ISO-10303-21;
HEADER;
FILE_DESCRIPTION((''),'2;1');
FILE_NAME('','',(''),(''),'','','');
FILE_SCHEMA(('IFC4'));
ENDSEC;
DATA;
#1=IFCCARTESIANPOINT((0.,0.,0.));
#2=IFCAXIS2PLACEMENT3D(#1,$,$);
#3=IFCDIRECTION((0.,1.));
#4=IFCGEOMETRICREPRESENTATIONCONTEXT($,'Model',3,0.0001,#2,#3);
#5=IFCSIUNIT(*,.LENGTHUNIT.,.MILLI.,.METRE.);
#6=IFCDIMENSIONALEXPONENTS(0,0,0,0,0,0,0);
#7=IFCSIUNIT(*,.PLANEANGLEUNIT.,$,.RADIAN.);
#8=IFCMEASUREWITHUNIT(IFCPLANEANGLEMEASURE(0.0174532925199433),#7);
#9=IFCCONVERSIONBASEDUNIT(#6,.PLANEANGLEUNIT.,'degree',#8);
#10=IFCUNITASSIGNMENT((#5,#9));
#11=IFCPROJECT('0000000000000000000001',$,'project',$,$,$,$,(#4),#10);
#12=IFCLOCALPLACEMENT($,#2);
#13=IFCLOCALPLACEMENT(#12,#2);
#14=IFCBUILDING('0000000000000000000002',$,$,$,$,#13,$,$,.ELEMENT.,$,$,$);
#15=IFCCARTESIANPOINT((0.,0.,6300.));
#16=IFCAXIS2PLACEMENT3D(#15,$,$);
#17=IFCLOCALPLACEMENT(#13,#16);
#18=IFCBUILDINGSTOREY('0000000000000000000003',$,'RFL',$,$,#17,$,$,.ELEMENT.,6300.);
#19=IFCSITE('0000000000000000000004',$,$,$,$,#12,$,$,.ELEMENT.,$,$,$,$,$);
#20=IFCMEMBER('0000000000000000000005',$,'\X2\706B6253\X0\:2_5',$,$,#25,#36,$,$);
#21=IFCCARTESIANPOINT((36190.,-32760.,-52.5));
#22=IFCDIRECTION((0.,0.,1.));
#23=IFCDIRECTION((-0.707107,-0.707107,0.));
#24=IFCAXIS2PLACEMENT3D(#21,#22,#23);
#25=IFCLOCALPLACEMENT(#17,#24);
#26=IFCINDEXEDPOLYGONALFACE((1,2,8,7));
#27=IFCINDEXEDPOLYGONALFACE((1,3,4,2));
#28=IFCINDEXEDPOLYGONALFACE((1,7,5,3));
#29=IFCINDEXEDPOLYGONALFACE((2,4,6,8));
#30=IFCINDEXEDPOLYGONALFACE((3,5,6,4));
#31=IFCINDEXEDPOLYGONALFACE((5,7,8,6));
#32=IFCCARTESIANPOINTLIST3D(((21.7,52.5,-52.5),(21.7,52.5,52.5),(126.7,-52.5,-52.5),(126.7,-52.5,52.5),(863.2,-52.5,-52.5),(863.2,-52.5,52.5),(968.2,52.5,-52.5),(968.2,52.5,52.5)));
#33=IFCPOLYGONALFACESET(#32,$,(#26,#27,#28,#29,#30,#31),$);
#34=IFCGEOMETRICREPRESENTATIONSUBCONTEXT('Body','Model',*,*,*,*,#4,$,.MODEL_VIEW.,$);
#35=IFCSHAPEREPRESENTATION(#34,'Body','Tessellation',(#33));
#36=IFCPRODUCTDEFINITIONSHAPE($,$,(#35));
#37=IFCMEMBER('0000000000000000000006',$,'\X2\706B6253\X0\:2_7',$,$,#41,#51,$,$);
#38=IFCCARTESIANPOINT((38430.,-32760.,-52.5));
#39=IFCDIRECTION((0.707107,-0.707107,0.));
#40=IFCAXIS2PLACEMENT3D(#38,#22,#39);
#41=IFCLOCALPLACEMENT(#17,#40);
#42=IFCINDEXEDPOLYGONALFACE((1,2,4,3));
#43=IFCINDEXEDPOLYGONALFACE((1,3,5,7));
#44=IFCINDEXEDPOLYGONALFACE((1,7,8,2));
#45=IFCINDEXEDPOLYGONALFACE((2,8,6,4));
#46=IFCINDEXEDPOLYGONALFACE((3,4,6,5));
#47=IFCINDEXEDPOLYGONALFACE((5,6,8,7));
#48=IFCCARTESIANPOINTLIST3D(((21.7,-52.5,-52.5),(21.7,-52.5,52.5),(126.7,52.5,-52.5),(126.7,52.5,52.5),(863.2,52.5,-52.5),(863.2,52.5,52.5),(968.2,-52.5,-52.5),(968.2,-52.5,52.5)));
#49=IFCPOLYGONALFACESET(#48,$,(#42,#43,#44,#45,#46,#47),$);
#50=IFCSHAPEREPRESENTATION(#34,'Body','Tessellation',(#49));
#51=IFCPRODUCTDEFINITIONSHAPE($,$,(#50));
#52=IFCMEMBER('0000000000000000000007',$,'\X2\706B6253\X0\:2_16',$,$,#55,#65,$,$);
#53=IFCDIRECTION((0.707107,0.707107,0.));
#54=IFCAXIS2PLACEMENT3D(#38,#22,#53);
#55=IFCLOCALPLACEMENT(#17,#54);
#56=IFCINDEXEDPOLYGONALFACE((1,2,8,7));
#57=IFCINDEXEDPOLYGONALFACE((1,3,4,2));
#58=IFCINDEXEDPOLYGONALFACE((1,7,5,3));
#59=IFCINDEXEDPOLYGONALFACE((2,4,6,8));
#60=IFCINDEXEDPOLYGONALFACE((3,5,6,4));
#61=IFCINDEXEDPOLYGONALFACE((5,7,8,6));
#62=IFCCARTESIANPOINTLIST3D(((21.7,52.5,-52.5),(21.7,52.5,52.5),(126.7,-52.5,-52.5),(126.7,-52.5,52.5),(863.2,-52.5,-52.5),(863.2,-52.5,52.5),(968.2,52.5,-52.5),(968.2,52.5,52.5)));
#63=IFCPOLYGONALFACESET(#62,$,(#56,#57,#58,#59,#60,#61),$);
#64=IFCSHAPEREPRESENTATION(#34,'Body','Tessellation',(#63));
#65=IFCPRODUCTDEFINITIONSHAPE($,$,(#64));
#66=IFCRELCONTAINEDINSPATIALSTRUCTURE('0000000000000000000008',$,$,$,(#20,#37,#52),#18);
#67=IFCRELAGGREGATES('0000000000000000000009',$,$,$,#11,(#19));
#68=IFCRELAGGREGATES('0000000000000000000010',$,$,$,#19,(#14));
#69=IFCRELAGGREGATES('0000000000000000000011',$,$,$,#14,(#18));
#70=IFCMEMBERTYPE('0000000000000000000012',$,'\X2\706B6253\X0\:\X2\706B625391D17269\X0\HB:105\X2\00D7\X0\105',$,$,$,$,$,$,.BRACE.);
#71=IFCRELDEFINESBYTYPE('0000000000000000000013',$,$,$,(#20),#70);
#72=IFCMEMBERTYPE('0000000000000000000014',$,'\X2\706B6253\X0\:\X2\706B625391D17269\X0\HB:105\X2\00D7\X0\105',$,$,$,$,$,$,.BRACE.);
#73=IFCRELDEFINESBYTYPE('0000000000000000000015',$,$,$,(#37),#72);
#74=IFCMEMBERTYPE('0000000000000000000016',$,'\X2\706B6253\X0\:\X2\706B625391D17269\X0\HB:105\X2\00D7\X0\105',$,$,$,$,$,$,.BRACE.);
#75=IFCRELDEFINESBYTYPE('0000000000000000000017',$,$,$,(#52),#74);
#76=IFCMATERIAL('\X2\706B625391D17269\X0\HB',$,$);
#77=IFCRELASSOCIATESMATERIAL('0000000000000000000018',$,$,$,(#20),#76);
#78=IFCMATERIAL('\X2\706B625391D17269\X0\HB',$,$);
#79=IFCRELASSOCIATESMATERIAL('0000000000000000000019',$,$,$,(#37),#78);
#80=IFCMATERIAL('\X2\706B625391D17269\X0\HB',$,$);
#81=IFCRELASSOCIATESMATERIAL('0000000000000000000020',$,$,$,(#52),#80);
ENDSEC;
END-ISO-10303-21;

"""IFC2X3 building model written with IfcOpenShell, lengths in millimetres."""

from ifc_helpers import new_model, entity, si_unit, converted_unit, direction, frame, origin, place, context, subcontext, project, spatial, polyline, outline, extrude, material, type_object, element, save


model = new_model("IFC2X3")

# Units and contexts
model_context = context("Model", 3, precision=0.0001, world=origin(), true_north=direction((0.0, 1.0)))
body_context = subcontext(model_context, "Body", "Model", "MODEL_VIEW")
ifc_project = project(units=[si_unit("LENGTHUNIT", "METRE", prefix="MILLI"), converted_unit("PLANEANGLEUNIT", "degree", entity("IfcPlaneAngleMeasure", 0.0174532925199433), si_unit("PLANEANGLEUNIT", "RADIAN"), dimensions=[0, 0, 0, 0, 0, 0, 0])], contexts=[model_context])

# Site, building, storey
site_placement = place(None, origin())
site = spatial("IfcSite", under=ifc_project, at=site_placement, CompositionType="ELEMENT")
building_placement = place(site_placement, origin())
building = spatial("IfcBuilding", under=site, at=building_placement, CompositionType="ELEMENT")
storey_placement = place(building_placement, frame((0.0, 0.0, 6300.0)))
storey = spatial("IfcBuildingStorey", under=building, at=storey_placement, Name="RFL", CompositionType="ELEMENT", Elevation=6300.0)

# Members
ifc_material_1 = material(Name="火打金物HB")
member_type_1 = type_object("IfcMemberType", Name="火打:火打金物HB:105×105", PredefinedType="BRACE")
member_1_placement = place(storey_placement, frame((36190.0, -32760.0, -52.5), z_axis=(0.0, 0.0, 1.0), x_axis=(-0.707107, -0.707107, 0.0)))
element("IfcMember", 1, at=member_1_placement, inside=storey, type_object=member_type_1, material=ifc_material_1, Name="火打:2_5", context=body_context, shape_type="SweptSolid", body=[
    extrude(outline(polyline([(126.7, -52.5, 0.0), (21.7, 52.5, 0.0), (968.2, 52.5, 0.0), (863.2, -52.5, 0.0), (126.7, -52.5, 0.0)])), frame((0.0, 0.0, -52.5), z_axis=(0.0, 0.0, 1.0), x_axis=(1.0, 0.0, 0.0)), (0.0, 0.0, 1.0), 105.0),
])
ifc_material_2 = material(Name="火打金物HB")
member_type_2 = type_object("IfcMemberType", Name="火打:火打金物HB:105×105", PredefinedType="BRACE")
member_2_placement = place(storey_placement, frame((38430.0, -32760.0, -52.5), z_axis=(0.0, 0.0, 1.0), x_axis=(0.707107, -0.707107, 0.0)))
element("IfcMember", 2, at=member_2_placement, inside=storey, type_object=member_type_2, material=ifc_material_2, Name="火打:2_7", context=body_context, shape_type="SweptSolid", body=[
    extrude(outline(polyline([(21.7, -52.5, 0.0), (126.7, 52.5, 0.0), (863.2, 52.5, 0.0), (968.2, -52.5, 0.0), (21.7, -52.5, 0.0)])), frame((0.0, 0.0, -52.5), z_axis=(0.0, 0.0, 1.0), x_axis=(1.0, 0.0, 0.0)), (0.0, 0.0, 1.0), 105.0),
])
ifc_material_3 = material(Name="火打金物HB")
member_type_3 = type_object("IfcMemberType", Name="火打:火打金物HB:105×105", PredefinedType="BRACE")
member_3_placement = place(storey_placement, frame((38430.0, -32760.0, -52.5), z_axis=(0.0, 0.0, 1.0), x_axis=(0.707107, 0.707107, 0.0)))
element("IfcMember", 3, at=member_3_placement, inside=storey, type_object=member_type_3, material=ifc_material_3, Name="火打:2_16", context=body_context, shape_type="SweptSolid", body=[
    extrude(outline(polyline([(126.7, -52.5, 0.0), (21.7, 52.5, 0.0), (968.2, 52.5, 0.0), (863.2, -52.5, 0.0), (126.7, -52.5, 0.0)])), frame((0.0, 0.0, -52.5), z_axis=(0.0, 0.0, 1.0), x_axis=(1.0, 0.0, 0.0)), (0.0, 0.0, 1.0), 105.0),
])

save(model, "model.ifc")
